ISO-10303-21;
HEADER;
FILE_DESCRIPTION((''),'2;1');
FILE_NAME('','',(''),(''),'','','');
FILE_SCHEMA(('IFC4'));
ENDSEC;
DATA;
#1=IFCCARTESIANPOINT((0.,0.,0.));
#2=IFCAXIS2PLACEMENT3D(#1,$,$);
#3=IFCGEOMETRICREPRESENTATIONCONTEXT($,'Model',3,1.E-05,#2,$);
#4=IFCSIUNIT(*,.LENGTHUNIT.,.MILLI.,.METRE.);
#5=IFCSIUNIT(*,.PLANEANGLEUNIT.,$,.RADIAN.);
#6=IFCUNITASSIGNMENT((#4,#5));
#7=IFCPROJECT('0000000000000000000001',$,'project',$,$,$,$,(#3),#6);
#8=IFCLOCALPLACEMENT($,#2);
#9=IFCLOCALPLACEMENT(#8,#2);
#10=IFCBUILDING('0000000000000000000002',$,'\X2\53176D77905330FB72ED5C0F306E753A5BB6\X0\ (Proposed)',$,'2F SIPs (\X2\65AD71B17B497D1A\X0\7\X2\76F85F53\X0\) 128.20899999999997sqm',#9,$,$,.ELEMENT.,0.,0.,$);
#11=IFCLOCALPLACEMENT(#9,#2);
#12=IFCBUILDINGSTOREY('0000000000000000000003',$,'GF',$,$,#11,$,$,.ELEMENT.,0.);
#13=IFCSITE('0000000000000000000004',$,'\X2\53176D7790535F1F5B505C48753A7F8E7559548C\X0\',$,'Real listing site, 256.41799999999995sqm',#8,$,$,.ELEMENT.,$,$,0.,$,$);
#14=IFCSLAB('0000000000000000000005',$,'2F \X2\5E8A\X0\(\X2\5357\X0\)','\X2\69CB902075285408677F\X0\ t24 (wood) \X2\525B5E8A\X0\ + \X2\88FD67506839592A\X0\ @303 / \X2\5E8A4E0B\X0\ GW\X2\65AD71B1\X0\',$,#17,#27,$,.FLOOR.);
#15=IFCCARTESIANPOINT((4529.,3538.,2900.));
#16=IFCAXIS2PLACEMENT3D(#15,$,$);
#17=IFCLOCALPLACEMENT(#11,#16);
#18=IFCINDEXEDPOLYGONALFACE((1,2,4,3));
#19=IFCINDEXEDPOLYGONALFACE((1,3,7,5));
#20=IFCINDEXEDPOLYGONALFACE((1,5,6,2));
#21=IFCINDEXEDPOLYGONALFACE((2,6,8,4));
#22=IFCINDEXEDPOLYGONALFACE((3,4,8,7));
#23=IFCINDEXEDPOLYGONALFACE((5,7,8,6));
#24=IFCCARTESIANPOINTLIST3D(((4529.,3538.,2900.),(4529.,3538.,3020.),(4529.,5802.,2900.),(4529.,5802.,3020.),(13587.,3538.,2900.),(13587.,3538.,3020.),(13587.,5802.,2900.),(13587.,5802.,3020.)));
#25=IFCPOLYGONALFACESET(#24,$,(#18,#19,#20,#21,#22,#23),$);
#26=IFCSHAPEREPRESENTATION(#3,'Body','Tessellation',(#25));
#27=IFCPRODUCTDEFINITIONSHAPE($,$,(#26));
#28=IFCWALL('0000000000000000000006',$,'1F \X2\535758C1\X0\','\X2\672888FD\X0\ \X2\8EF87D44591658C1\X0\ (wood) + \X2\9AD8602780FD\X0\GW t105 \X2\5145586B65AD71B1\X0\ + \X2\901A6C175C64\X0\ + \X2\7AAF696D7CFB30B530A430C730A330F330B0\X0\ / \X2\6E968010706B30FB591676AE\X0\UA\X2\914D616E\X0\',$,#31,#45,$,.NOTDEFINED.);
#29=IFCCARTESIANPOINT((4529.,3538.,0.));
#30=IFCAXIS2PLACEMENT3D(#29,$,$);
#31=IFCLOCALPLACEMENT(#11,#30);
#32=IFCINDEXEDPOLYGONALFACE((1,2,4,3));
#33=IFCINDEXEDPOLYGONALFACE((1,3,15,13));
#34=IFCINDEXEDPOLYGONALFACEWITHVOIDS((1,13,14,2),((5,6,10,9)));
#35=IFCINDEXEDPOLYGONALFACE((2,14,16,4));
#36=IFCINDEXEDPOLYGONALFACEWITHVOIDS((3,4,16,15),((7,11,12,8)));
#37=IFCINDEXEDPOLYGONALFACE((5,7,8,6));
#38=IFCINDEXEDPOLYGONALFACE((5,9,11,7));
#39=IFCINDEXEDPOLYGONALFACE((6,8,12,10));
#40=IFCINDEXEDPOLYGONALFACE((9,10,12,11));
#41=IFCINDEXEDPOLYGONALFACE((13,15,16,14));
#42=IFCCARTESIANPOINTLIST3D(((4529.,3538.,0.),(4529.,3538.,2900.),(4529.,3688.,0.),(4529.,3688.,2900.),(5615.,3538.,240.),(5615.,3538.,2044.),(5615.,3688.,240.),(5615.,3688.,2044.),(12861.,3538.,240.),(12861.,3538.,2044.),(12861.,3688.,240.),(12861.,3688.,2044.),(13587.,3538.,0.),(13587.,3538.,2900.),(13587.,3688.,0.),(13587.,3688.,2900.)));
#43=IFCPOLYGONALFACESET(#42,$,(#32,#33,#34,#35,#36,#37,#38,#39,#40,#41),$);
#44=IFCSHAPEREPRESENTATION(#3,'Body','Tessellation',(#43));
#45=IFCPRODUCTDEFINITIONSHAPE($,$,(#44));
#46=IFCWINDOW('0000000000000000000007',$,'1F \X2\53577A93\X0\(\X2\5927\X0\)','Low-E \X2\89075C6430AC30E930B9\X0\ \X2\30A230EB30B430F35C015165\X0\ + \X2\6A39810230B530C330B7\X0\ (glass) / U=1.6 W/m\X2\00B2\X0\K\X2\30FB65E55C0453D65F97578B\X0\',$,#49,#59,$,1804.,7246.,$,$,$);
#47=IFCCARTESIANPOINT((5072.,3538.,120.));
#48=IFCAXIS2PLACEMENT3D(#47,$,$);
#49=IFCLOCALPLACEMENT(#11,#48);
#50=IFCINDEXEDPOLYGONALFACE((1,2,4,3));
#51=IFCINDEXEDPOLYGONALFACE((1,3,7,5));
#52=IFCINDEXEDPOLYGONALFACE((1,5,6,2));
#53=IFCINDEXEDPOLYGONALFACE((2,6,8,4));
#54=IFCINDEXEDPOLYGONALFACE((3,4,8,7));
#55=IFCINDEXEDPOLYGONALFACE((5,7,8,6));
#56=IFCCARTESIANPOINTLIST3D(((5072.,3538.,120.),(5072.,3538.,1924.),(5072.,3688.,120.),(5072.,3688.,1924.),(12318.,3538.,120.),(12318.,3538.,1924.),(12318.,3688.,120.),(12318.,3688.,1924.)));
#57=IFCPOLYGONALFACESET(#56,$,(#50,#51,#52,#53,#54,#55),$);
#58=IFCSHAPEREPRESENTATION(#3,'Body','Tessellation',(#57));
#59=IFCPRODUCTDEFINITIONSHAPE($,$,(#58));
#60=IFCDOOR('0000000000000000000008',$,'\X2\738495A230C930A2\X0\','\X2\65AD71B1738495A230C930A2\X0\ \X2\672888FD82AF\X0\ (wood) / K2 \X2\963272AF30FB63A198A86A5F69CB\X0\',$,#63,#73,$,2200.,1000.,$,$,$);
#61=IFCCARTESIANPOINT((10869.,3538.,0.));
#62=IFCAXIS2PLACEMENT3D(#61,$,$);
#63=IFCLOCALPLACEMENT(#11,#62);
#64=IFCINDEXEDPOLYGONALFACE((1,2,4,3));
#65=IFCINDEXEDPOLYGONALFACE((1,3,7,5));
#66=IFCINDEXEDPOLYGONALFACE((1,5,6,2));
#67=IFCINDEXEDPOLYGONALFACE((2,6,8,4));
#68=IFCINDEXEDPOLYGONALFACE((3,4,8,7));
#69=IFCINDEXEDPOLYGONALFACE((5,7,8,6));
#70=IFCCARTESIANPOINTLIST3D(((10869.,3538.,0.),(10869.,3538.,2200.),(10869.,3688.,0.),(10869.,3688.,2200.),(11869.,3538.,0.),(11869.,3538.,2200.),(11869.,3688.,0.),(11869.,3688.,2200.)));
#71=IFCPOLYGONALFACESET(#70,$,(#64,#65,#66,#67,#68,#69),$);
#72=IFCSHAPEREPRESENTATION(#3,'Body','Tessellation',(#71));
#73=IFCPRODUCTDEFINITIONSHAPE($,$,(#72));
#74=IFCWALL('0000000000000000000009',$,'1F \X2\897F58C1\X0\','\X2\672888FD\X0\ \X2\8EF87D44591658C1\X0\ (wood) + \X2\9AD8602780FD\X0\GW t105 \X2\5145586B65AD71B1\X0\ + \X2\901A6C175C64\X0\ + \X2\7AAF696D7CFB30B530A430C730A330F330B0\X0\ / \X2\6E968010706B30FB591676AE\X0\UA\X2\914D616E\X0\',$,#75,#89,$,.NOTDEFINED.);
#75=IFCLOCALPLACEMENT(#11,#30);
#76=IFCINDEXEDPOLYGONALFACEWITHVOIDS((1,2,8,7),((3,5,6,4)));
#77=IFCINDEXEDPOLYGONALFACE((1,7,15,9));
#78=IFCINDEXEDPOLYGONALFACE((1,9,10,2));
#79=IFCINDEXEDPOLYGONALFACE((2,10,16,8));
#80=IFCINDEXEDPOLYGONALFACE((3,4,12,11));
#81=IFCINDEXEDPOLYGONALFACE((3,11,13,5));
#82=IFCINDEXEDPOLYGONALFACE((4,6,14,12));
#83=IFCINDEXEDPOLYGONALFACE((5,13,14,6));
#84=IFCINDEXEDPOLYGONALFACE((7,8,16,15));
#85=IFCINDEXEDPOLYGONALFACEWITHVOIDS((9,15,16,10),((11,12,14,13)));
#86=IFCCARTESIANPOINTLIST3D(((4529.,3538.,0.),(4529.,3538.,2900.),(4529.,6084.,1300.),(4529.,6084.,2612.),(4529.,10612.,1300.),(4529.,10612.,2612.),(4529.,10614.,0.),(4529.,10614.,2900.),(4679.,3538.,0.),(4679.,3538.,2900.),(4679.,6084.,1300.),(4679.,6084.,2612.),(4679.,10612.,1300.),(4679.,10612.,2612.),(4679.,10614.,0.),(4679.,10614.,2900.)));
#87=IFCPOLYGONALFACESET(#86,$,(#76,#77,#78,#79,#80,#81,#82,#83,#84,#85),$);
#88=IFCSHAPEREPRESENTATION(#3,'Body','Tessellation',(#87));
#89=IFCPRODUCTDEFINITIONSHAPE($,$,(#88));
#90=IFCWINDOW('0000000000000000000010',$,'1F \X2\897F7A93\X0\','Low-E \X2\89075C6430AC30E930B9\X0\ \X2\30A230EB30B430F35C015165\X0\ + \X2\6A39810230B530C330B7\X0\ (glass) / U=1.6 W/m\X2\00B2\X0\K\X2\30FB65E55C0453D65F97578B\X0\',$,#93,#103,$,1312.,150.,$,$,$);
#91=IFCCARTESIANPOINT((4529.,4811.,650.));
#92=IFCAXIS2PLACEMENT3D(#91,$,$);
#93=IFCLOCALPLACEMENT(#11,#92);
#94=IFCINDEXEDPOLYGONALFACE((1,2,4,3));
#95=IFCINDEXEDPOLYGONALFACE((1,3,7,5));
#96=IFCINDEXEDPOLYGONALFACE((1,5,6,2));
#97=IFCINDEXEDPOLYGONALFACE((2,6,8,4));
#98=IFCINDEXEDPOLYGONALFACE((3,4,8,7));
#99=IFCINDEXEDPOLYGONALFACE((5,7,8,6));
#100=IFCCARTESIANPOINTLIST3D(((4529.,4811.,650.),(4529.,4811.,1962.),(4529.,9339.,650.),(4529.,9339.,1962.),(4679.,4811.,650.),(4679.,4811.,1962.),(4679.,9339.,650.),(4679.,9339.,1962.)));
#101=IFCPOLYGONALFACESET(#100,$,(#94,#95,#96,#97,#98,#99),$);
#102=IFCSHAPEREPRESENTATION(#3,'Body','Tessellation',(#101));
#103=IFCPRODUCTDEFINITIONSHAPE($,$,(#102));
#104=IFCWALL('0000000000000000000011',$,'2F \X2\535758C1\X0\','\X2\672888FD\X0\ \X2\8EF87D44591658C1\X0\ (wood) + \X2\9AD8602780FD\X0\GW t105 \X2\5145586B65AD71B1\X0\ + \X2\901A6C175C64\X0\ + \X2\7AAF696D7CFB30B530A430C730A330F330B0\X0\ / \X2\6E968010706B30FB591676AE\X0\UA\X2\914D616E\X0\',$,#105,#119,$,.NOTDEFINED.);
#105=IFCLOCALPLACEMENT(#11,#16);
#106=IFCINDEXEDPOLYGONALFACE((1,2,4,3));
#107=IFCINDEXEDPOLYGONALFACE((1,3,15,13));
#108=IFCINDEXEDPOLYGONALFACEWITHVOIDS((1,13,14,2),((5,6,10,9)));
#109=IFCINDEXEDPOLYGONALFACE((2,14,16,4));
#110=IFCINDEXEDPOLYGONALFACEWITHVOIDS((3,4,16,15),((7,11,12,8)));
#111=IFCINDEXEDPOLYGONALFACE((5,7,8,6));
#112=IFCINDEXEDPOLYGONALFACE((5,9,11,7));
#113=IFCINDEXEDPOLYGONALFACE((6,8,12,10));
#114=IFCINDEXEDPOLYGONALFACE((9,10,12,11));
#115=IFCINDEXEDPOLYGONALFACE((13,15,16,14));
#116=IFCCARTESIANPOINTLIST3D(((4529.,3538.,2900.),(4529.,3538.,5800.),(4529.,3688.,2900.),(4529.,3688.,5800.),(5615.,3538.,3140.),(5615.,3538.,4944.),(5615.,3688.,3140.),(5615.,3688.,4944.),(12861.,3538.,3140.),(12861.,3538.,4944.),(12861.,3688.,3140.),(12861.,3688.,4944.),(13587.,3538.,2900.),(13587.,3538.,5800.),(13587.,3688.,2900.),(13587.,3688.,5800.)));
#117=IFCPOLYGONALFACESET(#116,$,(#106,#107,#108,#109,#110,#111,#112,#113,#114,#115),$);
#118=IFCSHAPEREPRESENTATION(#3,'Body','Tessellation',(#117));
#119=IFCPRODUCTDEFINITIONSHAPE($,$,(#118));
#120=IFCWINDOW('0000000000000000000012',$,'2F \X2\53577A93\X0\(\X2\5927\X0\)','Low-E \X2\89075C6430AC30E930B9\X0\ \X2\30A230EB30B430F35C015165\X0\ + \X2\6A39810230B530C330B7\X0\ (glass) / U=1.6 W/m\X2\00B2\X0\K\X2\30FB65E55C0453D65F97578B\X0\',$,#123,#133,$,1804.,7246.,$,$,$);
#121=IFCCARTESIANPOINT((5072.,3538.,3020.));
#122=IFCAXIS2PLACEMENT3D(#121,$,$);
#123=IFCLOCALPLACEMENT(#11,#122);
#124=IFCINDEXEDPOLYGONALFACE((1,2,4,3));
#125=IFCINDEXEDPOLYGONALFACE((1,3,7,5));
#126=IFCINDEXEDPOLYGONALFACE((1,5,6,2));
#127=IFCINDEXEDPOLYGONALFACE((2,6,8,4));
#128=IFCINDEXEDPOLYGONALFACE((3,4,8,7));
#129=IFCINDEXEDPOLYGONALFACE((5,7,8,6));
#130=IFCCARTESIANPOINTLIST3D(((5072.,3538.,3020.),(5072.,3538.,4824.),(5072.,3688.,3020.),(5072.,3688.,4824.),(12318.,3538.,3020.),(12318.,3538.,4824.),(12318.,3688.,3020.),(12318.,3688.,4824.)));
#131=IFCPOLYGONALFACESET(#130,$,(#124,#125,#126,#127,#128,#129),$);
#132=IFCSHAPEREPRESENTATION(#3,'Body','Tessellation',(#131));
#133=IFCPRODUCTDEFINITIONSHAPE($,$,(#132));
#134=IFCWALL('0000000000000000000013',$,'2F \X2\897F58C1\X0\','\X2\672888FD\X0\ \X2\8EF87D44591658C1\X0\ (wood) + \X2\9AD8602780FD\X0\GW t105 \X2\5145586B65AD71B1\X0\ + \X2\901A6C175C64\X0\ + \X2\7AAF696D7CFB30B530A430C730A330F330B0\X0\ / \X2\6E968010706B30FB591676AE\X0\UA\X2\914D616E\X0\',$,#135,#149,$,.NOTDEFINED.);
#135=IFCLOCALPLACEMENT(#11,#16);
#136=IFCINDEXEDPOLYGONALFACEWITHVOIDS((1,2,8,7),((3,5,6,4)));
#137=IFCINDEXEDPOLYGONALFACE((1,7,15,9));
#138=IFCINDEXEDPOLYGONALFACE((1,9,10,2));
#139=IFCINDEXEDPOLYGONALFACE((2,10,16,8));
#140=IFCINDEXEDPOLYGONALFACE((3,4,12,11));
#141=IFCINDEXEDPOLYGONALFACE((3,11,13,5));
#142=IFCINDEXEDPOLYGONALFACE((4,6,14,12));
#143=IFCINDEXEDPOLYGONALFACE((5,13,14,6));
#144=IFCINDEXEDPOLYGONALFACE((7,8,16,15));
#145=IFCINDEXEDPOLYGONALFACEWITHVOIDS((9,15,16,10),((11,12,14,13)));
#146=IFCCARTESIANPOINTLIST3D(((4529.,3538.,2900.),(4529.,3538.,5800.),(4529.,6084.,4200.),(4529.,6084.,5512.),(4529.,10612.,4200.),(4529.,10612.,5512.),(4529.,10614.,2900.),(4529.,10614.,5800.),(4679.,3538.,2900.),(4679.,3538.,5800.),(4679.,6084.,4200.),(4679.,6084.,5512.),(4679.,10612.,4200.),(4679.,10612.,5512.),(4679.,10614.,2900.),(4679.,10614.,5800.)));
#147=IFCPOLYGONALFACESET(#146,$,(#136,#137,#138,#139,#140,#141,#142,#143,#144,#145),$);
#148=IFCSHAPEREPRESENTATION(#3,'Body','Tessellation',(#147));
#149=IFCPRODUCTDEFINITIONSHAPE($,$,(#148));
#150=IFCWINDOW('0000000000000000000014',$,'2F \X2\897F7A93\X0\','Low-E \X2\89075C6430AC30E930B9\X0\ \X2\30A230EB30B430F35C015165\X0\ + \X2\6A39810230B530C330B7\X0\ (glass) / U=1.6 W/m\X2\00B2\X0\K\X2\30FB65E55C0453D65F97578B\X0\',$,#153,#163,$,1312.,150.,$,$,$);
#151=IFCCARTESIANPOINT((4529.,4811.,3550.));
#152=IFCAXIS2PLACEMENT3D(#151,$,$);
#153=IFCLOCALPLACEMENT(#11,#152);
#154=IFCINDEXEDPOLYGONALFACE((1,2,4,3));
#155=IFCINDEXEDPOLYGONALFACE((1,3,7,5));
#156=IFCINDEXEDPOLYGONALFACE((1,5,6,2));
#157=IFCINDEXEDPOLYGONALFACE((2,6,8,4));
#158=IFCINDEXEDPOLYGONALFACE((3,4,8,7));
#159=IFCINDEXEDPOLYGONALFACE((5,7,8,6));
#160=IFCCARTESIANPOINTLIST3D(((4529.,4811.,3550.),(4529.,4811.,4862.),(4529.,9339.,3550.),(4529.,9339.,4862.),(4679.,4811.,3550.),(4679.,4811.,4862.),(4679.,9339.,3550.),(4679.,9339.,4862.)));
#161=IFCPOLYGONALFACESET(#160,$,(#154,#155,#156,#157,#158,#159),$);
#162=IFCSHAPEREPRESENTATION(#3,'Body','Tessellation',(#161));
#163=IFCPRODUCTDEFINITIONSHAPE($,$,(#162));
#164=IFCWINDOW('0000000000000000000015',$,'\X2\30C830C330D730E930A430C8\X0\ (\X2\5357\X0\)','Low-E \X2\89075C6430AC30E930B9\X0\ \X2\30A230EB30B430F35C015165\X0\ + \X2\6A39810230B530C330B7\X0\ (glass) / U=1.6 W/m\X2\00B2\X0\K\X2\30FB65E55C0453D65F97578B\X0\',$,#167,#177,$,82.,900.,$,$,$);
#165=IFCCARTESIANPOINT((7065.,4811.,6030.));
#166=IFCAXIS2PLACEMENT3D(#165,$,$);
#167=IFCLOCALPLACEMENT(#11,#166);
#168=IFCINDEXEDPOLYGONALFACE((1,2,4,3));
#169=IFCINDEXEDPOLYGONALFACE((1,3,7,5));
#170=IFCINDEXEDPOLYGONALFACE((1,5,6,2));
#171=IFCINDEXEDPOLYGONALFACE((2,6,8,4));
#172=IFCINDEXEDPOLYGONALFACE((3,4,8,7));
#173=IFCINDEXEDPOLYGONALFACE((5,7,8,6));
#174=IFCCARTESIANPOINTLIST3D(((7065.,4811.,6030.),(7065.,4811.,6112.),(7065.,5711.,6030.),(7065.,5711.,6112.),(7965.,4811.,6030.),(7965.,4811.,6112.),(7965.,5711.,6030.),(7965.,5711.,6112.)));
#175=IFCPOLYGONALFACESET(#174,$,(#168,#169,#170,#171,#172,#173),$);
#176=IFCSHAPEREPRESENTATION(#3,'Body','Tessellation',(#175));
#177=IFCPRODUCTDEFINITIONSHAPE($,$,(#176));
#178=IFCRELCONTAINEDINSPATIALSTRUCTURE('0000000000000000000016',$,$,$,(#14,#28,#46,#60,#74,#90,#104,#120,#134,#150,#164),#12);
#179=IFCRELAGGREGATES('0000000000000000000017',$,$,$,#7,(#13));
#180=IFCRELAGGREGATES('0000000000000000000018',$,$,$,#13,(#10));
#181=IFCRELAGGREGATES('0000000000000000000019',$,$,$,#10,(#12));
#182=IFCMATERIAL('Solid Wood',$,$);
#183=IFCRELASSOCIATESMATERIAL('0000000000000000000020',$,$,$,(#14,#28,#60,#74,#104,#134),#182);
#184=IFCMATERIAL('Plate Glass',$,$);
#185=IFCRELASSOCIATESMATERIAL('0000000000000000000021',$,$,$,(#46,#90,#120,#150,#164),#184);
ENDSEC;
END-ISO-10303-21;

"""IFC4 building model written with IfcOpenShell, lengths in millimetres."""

from ifc_helpers import new_model, si_unit, frame, frame_2d, origin, place, context, project, spatial, rectangle, extrude, material, element, fill, save


model = new_model("IFC4")

# Units and contexts
model_context = context("Model", 3, precision=1e-05, world=origin())
ifc_project = project(units=[si_unit("LENGTHUNIT", "METRE", prefix="MILLI"), si_unit("PLANEANGLEUNIT", "RADIAN")], contexts=[model_context])

# Site, building, storey
site_placement = place(None, origin())
site = spatial("IfcSite", under=ifc_project, at=site_placement, Name="北海道弟子屈町美留和", ObjectType="Real listing site, 256.41799999999995sqm", CompositionType="ELEMENT", RefElevation=0.0)
building_placement = place(site_placement, origin())
building = spatial("IfcBuilding", under=site, at=building_placement, Name="北海道・狭小の町家 (Proposed)", ObjectType="2F SIPs (断熱等級7相当) 128.20899999999997sqm", CompositionType="ELEMENT", ElevationOfRefHeight=0.0, ElevationOfTerrain=0.0)
storey_placement = place(building_placement, origin())
storey = spatial("IfcBuildingStorey", under=building, at=storey_placement, Name="GF", CompositionType="ELEMENT", Elevation=0.0)

# Slab
ifc_material_1 = material(Name="Solid Wood")
slab_1_placement = place(storey_placement, frame((4529.0, 3538.0, 2900.0)))
element("IfcSlab", 1, at=slab_1_placement, inside=storey, material=ifc_material_1, Name="2F 床(南)", Description="構造用合板 t24 (wood) 剛床 + 製材根太 @303 / 床下 GW断熱", PredefinedType="FLOOR", context=model_context, shape_type="SweptSolid", body=[
    extrude(rectangle(XDim=9058.0, YDim=2264.0, at=frame_2d((4529.0, 1132.0))), frame((4529.0, 3538.0, 2900.0)), (0.0, 0.0, 1.0), 120.0),
])

# Wall, openings, window, door
wall_1_placement = place(storey_placement, frame((4529.0, 3538.0, 0.0)))
wall_1 = element("IfcWall", 2, at=wall_1_placement, inside=storey, material=ifc_material_1, Name="1F 南壁", Description="木製 軸組外壁 (wood) + 高性能GW t105 充填断熱 + 通気層 + 窯業系サイディング / 準耐火・外皮UA配慮", PredefinedType="NOTDEFINED", context=model_context, shape_type="SweptSolid", body=[
    extrude(rectangle(XDim=9058.0, YDim=150.0, at=frame_2d((4529.0, 75.0))), frame((4529.0, 3538.0, 0.0)), (0.0, 0.0, 1.0), 2900.0),
])
opening_1_placement = place(storey_placement, frame((5072.0, 3538.0, 120.0)))
opening_1 = element("IfcOpeningElement", 3, at=opening_1_placement, cuts=wall_1, PredefinedType="NOTDEFINED", context=model_context, shape_type="SweptSolid", body=[
    extrude(rectangle(XDim=7246.0, YDim=150.0, at=frame_2d((3623.0, 75.0))), frame((5072.0, 3538.0, 120.0)), (0.0, 0.0, 1.0), 1804.0),
])
opening_2_placement = place(storey_placement, frame((10869.0, 3538.0, 0.0)))
opening_2 = element("IfcOpeningElement", 4, at=opening_2_placement, cuts=wall_1, PredefinedType="NOTDEFINED", context=model_context, shape_type="SweptSolid", body=[
    extrude(rectangle(XDim=1000.0, YDim=150.0, at=frame_2d((500.0, 75.0))), frame((10869.0, 3538.0, 0.0)), (0.0, 0.0, 1.0), 2200.0),
])
ifc_material_2 = material(Name="Plate Glass")
window_1_placement = place(storey_placement, frame((5072.0, 3538.0, 120.0)))
window_1 = element("IfcWindow", 5, at=window_1_placement, inside=storey, material=ifc_material_2, Name="1F 南窓(大)", Description="Low-E 複層ガラス アルゴン封入 + 樹脂サッシ (glass) / U=1.6 W/m²K・日射取得型", OverallHeight=1804.0, OverallWidth=7246.0, context=model_context, shape_type="SweptSolid", body=[
    extrude(rectangle(XDim=7246.0, YDim=150.0, at=frame_2d((3623.0, 75.0))), frame((5072.0, 3538.0, 120.0)), (0.0, 0.0, 1.0), 1804.0),
])
fill(opening_1, window_1)
door_placement = place(storey_placement, frame((10869.0, 3538.0, 0.0)))
door = element("IfcDoor", 6, at=door_placement, inside=storey, material=ifc_material_1, Name="玄関ドア", Description="断熱玄関ドア 木製芯 (wood) / K2 防犯・採風機構", OverallHeight=2200.0, OverallWidth=1000.0, context=model_context, shape_type="SweptSolid", body=[
    extrude(rectangle(XDim=1000.0, YDim=150.0, at=frame_2d((500.0, 75.0))), frame((10869.0, 3538.0, 0.0)), (0.0, 0.0, 1.0), 2200.0),
])
fill(opening_2, door)

# Walls, openings, windows
wall_2_placement = place(storey_placement, frame((4529.0, 3538.0, 0.0)))
wall_2 = element("IfcWall", 7, at=wall_2_placement, inside=storey, material=ifc_material_1, Name="1F 西壁", Description="木製 軸組外壁 (wood) + 高性能GW t105 充填断熱 + 通気層 + 窯業系サイディング / 準耐火・外皮UA配慮", PredefinedType="NOTDEFINED", context=model_context, shape_type="SweptSolid", body=[
    extrude(rectangle(XDim=150.0, YDim=7076.0, at=frame_2d((75.0, 3538.0))), frame((4529.0, 3538.0, 0.0)), (0.0, 0.0, 1.0), 2900.0),
])
opening_3_placement = place(storey_placement, frame((4529.0, 4811.0, 650.0)))
opening_3 = element("IfcOpeningElement", 8, at=opening_3_placement, cuts=wall_2, PredefinedType="NOTDEFINED", context=model_context, shape_type="SweptSolid", body=[
    extrude(rectangle(XDim=150.0, YDim=4528.0, at=frame_2d((75.0, 2264.0))), frame((4529.0, 4811.0, 650.0)), (0.0, 0.0, 1.0), 1312.0),
])
window_2_placement = place(storey_placement, frame((4529.0, 4811.0, 650.0)))
window_2 = element("IfcWindow", 9, at=window_2_placement, inside=storey, material=ifc_material_2, Name="1F 西窓", Description="Low-E 複層ガラス アルゴン封入 + 樹脂サッシ (glass) / U=1.6 W/m²K・日射取得型", OverallHeight=1312.0, OverallWidth=150.0, context=model_context, shape_type="SweptSolid", body=[
    extrude(rectangle(XDim=150.0, YDim=4528.0, at=frame_2d((75.0, 2264.0))), frame((4529.0, 4811.0, 650.0)), (0.0, 0.0, 1.0), 1312.0),
])
fill(opening_3, window_2)
wall_3_placement = place(storey_placement, frame((4529.0, 3538.0, 2900.0)))
wall_3 = element("IfcWall", 10, at=wall_3_placement, inside=storey, material=ifc_material_1, Name="2F 南壁", Description="木製 軸組外壁 (wood) + 高性能GW t105 充填断熱 + 通気層 + 窯業系サイディング / 準耐火・外皮UA配慮", PredefinedType="NOTDEFINED", context=model_context, shape_type="SweptSolid", body=[
    extrude(rectangle(XDim=9058.0, YDim=150.0, at=frame_2d((4529.0, 75.0))), frame((4529.0, 3538.0, 2900.0)), (0.0, 0.0, 1.0), 2900.0),
])
opening_4_placement = place(storey_placement, frame((5072.0, 3538.0, 3020.0)))
opening_4 = element("IfcOpeningElement", 11, at=opening_4_placement, cuts=wall_3, PredefinedType="NOTDEFINED", context=model_context, shape_type="SweptSolid", body=[
    extrude(rectangle(XDim=7246.0, YDim=150.0, at=frame_2d((3623.0, 75.0))), frame((5072.0, 3538.0, 3020.0)), (0.0, 0.0, 1.0), 1804.0),
])
window_3_placement = place(storey_placement, frame((5072.0, 3538.0, 3020.0)))
window_3 = element("IfcWindow", 12, at=window_3_placement, inside=storey, material=ifc_material_2, Name="2F 南窓(大)", Description="Low-E 複層ガラス アルゴン封入 + 樹脂サッシ (glass) / U=1.6 W/m²K・日射取得型", OverallHeight=1804.0, OverallWidth=7246.0, context=model_context, shape_type="SweptSolid", body=[
    extrude(rectangle(XDim=7246.0, YDim=150.0, at=frame_2d((3623.0, 75.0))), frame((5072.0, 3538.0, 3020.0)), (0.0, 0.0, 1.0), 1804.0),
])
fill(opening_4, window_3)
wall_4_placement = place(storey_placement, frame((4529.0, 3538.0, 2900.0)))
wall_4 = element("IfcWall", 13, at=wall_4_placement, inside=storey, material=ifc_material_1, Name="2F 西壁", Description="木製 軸組外壁 (wood) + 高性能GW t105 充填断熱 + 通気層 + 窯業系サイディング / 準耐火・外皮UA配慮", PredefinedType="NOTDEFINED", context=model_context, shape_type="SweptSolid", body=[
    extrude(rectangle(XDim=150.0, YDim=7076.0, at=frame_2d((75.0, 3538.0))), frame((4529.0, 3538.0, 2900.0)), (0.0, 0.0, 1.0), 2900.0),
])
opening_5_placement = place(storey_placement, frame((4529.0, 4811.0, 3550.0)))
opening_5 = element("IfcOpeningElement", 14, at=opening_5_placement, cuts=wall_4, PredefinedType="NOTDEFINED", context=model_context, shape_type="SweptSolid", body=[
    extrude(rectangle(XDim=150.0, YDim=4528.0, at=frame_2d((75.0, 2264.0))), frame((4529.0, 4811.0, 3550.0)), (0.0, 0.0, 1.0), 1312.0),
])
window_4_placement = place(storey_placement, frame((4529.0, 4811.0, 3550.0)))
window_4 = element("IfcWindow", 15, at=window_4_placement, inside=storey, material=ifc_material_2, Name="2F 西窓", Description="Low-E 複層ガラス アルゴン封入 + 樹脂サッシ (glass) / U=1.6 W/m²K・日射取得型", OverallHeight=1312.0, OverallWidth=150.0, context=model_context, shape_type="SweptSolid", body=[
    extrude(rectangle(XDim=150.0, YDim=4528.0, at=frame_2d((75.0, 2264.0))), frame((4529.0, 4811.0, 3550.0)), (0.0, 0.0, 1.0), 1312.0),
])
fill(opening_5, window_4)

# Window
window_5_placement = place(storey_placement, frame((7065.0, 4811.0, 6030.0)))
element("IfcWindow", 16, at=window_5_placement, inside=storey, material=ifc_material_2, Name="トップライト (南)", Description="Low-E 複層ガラス アルゴン封入 + 樹脂サッシ (glass) / U=1.6 W/m²K・日射取得型", OverallHeight=82.0, OverallWidth=900.0, context=model_context, shape_type="SweptSolid", body=[
    extrude(rectangle(XDim=900.0, YDim=900.0, at=frame_2d((450.0, 450.0))), frame((7065.0, 4811.0, 6030.0)), (0.0, 0.0, 1.0), 82.0),
])

save(model, "model.ifc")
